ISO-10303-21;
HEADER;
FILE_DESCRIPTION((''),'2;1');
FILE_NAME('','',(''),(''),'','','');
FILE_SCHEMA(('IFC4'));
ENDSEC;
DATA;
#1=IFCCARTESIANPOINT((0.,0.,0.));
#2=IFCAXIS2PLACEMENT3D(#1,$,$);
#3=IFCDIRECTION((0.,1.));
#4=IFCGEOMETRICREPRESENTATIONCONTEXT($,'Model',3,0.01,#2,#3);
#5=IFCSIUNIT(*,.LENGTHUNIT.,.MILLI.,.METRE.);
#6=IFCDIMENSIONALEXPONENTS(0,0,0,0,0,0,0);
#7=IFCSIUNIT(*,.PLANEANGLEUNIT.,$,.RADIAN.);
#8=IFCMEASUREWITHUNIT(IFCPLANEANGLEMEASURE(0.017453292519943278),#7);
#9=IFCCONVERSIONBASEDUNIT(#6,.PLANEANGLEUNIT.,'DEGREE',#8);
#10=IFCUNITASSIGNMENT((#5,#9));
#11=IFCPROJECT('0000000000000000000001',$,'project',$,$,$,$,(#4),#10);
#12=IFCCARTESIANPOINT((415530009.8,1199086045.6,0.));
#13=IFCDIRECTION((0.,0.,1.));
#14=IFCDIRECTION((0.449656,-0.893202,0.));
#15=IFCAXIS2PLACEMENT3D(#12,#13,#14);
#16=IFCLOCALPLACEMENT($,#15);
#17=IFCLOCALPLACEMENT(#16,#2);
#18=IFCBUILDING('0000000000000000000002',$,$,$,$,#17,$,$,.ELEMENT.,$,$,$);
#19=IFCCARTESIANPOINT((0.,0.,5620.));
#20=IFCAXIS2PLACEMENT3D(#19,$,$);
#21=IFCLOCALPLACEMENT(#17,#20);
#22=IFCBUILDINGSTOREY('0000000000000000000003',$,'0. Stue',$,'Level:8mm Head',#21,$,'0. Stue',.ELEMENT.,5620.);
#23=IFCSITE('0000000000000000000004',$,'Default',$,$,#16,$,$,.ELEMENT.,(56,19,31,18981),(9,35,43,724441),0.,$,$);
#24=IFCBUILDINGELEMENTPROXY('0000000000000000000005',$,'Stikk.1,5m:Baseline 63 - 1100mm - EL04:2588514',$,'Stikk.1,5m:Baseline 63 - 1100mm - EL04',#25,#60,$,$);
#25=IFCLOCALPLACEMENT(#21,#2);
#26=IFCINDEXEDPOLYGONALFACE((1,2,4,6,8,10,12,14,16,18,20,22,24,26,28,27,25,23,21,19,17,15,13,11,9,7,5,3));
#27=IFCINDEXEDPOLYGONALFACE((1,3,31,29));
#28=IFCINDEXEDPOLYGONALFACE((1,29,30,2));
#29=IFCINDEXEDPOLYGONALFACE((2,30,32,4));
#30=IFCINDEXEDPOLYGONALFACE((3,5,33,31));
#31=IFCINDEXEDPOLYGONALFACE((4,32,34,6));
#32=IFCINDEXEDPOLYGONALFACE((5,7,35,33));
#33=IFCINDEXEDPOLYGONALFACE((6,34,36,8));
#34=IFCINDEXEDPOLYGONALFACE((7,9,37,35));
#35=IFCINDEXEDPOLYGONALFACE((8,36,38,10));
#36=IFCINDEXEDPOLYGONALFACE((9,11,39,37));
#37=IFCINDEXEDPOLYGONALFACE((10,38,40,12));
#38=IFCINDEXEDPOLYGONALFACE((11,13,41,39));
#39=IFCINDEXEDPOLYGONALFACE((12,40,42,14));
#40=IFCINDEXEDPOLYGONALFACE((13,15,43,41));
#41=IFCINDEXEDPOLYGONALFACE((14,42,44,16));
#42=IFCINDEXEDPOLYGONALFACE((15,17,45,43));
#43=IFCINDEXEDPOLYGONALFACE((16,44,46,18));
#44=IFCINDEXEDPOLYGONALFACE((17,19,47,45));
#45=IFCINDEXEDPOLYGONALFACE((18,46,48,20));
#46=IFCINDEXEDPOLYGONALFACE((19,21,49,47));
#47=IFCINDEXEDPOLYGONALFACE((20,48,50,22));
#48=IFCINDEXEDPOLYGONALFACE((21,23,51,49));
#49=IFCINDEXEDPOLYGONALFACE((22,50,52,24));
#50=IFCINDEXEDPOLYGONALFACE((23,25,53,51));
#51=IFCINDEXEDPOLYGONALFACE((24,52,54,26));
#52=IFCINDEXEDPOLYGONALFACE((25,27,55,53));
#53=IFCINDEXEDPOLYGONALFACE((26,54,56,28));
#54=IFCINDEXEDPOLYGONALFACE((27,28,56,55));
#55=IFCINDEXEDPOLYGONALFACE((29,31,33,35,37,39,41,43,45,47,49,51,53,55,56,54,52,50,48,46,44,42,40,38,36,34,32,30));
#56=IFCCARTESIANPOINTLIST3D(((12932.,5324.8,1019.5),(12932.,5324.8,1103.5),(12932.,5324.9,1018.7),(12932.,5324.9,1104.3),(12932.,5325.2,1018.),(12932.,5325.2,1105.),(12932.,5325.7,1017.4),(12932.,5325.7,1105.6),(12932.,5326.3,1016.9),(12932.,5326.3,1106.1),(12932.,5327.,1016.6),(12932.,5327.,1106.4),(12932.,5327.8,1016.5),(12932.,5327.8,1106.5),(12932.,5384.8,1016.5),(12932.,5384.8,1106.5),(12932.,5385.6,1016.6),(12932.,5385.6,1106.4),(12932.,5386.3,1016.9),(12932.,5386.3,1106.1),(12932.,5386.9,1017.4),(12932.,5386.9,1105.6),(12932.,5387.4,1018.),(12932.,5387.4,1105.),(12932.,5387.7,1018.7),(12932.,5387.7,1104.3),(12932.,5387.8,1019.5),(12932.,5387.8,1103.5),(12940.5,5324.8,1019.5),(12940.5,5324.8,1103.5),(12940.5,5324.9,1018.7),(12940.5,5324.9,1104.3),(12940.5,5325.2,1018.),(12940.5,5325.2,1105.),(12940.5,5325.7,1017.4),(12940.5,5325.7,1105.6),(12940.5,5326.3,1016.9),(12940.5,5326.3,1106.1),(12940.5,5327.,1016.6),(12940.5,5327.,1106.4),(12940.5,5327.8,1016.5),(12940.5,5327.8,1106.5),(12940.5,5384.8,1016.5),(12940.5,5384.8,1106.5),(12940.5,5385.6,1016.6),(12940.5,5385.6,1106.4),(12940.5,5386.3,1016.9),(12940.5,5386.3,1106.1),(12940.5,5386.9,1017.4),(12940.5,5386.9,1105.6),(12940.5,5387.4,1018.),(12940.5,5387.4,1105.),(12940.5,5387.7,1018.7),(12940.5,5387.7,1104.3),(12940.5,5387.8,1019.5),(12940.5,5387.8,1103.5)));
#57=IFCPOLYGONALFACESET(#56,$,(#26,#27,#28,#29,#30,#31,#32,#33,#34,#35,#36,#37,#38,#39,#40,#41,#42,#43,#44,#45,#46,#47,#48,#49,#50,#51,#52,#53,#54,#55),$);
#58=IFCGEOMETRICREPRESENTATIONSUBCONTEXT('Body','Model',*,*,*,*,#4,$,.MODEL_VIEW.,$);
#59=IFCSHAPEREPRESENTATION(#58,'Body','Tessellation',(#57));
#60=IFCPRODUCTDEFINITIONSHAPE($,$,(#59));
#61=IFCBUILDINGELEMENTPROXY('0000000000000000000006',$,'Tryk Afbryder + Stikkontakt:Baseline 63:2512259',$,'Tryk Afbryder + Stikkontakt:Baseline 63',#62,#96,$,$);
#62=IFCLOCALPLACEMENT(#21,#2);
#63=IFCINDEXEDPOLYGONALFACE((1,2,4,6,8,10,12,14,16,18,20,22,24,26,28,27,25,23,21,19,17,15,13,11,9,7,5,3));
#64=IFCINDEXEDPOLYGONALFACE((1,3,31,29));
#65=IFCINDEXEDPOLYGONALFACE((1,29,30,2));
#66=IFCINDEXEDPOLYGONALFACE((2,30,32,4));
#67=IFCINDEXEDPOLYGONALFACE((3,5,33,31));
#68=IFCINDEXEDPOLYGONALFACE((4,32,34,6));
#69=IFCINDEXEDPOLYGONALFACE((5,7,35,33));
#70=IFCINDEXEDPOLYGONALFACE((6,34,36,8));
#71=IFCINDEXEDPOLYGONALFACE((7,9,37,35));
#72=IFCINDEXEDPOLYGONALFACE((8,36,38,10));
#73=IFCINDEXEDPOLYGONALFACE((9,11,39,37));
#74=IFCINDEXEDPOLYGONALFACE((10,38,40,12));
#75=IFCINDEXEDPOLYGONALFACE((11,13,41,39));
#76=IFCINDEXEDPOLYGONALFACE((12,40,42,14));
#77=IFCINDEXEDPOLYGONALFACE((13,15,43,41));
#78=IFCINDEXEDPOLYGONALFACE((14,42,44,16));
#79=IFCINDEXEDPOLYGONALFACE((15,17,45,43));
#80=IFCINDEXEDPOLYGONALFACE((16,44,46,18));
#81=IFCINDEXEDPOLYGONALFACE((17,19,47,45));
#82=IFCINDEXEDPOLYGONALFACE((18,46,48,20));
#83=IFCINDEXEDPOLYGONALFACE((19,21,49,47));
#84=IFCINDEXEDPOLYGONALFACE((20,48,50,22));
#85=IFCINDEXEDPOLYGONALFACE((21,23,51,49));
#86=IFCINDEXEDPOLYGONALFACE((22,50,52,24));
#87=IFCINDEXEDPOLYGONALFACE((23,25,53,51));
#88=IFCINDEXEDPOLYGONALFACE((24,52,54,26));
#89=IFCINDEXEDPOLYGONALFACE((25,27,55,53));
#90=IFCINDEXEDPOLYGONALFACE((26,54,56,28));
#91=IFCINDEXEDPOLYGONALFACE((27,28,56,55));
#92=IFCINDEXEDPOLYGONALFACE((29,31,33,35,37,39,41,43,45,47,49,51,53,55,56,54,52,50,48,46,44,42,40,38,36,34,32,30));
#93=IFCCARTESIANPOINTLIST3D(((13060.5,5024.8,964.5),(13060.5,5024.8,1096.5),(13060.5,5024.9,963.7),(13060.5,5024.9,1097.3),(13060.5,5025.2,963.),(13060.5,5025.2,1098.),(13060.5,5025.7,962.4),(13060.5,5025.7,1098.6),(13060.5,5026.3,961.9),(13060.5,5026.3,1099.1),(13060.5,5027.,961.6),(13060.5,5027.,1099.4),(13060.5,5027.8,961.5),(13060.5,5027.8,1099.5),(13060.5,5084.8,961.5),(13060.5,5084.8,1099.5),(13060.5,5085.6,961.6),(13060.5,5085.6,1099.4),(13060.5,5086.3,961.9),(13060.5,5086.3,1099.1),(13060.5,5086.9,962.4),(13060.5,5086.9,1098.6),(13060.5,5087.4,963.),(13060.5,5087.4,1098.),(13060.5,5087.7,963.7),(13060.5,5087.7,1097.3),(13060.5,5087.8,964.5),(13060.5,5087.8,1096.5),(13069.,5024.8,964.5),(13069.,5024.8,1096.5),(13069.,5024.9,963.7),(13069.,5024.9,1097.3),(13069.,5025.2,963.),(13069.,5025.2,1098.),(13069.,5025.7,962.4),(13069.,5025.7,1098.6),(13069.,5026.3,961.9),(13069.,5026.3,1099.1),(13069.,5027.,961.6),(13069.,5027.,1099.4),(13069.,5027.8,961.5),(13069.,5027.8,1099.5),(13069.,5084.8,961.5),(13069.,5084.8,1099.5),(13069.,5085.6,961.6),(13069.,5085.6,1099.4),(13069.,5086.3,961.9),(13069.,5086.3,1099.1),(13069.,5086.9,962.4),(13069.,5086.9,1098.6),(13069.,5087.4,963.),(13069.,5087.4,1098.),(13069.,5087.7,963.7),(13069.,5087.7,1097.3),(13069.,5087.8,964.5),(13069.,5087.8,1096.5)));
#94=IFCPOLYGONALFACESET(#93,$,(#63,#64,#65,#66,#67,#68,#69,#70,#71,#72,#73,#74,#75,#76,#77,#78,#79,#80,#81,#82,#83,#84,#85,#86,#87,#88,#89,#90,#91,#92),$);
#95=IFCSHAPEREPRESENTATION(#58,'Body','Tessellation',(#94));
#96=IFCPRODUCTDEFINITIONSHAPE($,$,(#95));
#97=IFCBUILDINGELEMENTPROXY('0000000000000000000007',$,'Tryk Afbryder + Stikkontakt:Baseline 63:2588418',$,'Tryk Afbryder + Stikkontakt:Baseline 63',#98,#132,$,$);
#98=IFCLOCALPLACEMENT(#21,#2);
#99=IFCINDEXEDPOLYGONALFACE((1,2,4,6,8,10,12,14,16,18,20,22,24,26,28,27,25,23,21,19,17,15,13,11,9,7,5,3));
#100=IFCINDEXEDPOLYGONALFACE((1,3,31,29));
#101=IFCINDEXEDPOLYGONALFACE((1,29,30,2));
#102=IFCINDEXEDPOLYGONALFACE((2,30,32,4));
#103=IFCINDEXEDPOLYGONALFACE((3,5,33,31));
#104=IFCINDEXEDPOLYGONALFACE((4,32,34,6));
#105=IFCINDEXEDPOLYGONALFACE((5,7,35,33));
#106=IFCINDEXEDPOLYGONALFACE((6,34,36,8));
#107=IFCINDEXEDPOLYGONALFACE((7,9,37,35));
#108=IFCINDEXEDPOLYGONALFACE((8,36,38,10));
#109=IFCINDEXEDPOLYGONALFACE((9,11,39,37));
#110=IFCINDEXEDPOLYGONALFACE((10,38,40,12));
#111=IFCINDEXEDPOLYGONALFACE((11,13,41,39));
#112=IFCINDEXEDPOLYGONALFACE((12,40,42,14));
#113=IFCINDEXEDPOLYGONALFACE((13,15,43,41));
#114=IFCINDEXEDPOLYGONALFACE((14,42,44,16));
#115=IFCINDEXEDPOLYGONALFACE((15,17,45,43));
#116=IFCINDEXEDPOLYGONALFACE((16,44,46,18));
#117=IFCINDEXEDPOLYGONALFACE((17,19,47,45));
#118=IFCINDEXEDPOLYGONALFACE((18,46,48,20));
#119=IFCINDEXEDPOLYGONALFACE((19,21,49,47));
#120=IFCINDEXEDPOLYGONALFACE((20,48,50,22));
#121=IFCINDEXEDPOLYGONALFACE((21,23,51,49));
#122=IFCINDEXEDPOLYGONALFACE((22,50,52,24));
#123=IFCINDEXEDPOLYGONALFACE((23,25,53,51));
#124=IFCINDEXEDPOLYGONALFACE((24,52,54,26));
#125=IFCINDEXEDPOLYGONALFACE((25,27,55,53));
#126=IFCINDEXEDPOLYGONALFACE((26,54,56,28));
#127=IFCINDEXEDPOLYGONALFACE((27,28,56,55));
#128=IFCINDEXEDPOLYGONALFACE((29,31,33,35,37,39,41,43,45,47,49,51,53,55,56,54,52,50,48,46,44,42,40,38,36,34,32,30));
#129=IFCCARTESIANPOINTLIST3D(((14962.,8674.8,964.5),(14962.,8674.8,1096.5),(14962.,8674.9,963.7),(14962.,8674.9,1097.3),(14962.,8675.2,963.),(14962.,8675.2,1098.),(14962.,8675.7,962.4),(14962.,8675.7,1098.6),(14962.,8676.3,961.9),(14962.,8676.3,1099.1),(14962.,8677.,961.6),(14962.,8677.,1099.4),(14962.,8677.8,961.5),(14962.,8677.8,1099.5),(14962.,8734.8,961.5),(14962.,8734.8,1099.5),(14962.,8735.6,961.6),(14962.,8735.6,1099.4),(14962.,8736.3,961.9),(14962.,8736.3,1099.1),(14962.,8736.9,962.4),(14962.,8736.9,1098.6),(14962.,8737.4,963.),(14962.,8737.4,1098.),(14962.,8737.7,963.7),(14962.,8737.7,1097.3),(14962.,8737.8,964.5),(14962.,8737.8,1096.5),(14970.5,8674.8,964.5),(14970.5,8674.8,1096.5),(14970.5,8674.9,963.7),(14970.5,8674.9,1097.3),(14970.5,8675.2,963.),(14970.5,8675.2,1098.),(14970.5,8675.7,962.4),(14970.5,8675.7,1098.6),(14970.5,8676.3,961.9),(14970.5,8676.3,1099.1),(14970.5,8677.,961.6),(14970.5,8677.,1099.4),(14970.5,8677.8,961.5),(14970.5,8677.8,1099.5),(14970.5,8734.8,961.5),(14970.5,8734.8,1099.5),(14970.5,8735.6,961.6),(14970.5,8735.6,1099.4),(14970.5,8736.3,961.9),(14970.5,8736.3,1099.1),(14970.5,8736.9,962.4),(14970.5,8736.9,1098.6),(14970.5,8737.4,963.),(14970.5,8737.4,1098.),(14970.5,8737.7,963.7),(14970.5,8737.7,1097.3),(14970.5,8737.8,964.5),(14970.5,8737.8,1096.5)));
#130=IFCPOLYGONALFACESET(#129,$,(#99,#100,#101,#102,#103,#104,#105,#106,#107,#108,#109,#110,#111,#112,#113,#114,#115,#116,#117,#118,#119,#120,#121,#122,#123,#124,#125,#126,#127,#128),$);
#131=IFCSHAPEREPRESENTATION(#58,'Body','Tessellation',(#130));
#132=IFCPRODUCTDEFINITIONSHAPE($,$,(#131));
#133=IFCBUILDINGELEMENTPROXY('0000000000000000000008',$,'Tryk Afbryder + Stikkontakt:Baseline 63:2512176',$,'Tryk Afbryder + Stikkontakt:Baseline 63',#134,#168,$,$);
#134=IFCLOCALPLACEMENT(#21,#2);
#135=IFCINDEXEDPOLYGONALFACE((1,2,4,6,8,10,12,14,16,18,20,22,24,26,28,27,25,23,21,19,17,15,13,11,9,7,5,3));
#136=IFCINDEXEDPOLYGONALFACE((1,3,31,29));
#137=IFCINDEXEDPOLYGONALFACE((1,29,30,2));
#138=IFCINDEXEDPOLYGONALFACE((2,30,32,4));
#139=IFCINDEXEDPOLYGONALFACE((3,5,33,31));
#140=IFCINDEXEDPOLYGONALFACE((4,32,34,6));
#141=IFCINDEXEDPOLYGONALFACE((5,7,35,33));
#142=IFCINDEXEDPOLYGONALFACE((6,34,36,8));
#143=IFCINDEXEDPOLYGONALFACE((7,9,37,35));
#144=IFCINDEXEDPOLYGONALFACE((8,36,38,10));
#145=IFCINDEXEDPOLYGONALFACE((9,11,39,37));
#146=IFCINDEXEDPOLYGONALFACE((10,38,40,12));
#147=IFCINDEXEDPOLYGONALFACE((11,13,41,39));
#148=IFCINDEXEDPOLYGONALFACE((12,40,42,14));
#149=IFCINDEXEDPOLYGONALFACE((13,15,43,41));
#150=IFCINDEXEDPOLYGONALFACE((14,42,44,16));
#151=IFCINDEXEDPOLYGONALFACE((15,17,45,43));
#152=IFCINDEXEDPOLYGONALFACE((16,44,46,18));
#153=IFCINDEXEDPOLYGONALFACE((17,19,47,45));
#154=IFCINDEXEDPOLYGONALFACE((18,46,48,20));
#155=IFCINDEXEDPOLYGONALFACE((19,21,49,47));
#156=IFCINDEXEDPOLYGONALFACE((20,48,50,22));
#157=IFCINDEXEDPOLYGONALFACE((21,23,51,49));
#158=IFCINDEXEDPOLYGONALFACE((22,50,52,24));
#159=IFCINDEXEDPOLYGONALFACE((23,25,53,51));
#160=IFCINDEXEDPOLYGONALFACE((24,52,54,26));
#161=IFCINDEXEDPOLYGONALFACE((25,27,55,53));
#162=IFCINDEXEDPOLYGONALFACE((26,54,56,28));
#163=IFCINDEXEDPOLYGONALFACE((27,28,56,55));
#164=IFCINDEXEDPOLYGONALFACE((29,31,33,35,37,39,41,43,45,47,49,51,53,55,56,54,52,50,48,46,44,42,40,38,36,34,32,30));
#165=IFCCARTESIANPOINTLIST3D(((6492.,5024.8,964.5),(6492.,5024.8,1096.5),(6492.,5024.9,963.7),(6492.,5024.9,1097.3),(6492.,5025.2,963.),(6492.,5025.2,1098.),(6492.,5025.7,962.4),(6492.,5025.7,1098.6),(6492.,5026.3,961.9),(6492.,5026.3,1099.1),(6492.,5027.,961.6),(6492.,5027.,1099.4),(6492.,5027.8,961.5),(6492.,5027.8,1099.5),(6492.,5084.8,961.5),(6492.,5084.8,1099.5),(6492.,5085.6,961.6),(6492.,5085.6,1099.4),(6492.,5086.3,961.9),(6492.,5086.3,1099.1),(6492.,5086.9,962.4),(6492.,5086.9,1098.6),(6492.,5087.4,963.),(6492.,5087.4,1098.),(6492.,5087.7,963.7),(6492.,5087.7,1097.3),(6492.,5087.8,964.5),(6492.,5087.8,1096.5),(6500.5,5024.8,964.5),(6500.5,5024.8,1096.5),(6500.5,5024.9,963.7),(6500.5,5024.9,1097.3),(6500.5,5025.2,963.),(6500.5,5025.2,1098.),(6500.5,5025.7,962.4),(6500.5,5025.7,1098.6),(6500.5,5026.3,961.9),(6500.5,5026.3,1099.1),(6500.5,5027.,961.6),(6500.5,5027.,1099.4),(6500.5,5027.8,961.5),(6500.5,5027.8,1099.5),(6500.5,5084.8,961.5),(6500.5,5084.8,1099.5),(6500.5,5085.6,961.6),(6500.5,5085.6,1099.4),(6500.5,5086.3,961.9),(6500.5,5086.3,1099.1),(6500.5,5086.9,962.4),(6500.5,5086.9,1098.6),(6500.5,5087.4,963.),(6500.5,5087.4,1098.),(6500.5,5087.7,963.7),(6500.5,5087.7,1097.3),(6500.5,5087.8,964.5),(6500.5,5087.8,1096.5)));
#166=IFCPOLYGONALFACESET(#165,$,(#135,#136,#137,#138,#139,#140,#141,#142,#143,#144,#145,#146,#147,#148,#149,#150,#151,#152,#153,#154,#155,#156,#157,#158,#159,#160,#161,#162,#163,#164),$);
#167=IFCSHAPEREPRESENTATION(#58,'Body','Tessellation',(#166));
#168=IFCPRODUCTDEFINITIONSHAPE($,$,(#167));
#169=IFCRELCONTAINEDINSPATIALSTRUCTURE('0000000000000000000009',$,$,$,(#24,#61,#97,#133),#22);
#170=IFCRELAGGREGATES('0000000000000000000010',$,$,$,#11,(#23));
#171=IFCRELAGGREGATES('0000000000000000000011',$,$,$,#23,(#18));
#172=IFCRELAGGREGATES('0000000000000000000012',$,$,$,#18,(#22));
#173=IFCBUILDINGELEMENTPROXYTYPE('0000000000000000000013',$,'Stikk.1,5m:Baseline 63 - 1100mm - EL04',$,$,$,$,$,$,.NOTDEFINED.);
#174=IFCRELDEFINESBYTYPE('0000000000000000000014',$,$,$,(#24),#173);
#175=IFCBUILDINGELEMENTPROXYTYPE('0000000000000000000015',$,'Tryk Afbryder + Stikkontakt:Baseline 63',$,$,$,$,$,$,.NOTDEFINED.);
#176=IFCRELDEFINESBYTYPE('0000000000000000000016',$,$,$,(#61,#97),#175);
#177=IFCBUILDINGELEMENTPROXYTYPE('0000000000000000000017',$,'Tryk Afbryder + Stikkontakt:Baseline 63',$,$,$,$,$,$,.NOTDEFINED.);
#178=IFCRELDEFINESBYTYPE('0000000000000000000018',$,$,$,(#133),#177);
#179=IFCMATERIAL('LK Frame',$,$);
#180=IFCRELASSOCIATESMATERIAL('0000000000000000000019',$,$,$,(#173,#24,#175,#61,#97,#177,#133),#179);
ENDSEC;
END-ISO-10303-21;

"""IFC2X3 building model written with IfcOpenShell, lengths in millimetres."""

from ifc_helpers import new_model, entity, si_unit, converted_unit, direction, frame, frame_2d, origin, place, context, subcontext, project, spatial, polyline, circle_curve, parameter, trimmed, segment, composite_curve, outline, extrude, source, transform, mapped, material, type_object, type_shapes, element, save


model = new_model("IFC2X3")

# Units and contexts
model_context = context("Model", 3, precision=0.01, world=origin(), true_north=direction((0.0, 1.0)))
body_context = subcontext(model_context, "Body", "Model", "MODEL_VIEW")
ifc_project = project(units=[si_unit("LENGTHUNIT", "METRE", prefix="MILLI"), converted_unit("PLANEANGLEUNIT", "DEGREE", entity("IfcPlaneAngleMeasure", 0.017453292519943278), si_unit("PLANEANGLEUNIT", "RADIAN"), dimensions=[0, 0, 0, 0, 0, 0, 0])], contexts=[model_context])

# Site, building, storey
site_placement = place(None, frame((415530009.8, 1199086045.6, 0.0), z_axis=(0.0, 0.0, 1.0), x_axis=(0.449656, -0.893202, 0.0)))
site = spatial("IfcSite", under=ifc_project, at=site_placement, Name="Default", CompositionType="ELEMENT", RefLatitude=(56, 19, 31, 18981), RefLongitude=(9, 35, 43, 724441), RefElevation=0.0)
building_placement = place(site_placement, origin())
building = spatial("IfcBuilding", under=site, at=building_placement, CompositionType="ELEMENT")
storey_placement = place(building_placement, frame((0.0, 0.0, 5620.0)))
storey = spatial("IfcBuildingStorey", under=building, at=storey_placement, Name="0. Stue", ObjectType="Level:8mm Head", LongName="0. Stue", CompositionType="ELEMENT", Elevation=5620.0)

# Building element proxies
ifc_material_1 = material(Name="LK Frame")
building_element_proxy_type_1 = type_object("IfcBuildingElementProxyType", Name="Stikk.1,5m:Baseline 63 - 1100mm - EL04", PredefinedType="NOTDEFINED", material=ifc_material_1)
shared_shape_1 = source(origin(), body_context, "Body", "SweptSolid", [
    extrude(outline(composite_curve([segment(polyline([(-42.0, -31.5), (42.0, -31.5)]), True, "CONTINUOUS"), segment(trimmed(circle_curve(frame_2d((42.0, -28.5), x_axis=(-1.0, 0.0)), 3.0), [parameter(90.0)], [parameter(180.0)], True, "PARAMETER"), True, "CONTINUOUS"), segment(polyline([(45.0, -28.5), (45.0, 28.5)]), True, "CONTINUOUS"), segment(trimmed(circle_curve(frame_2d((42.0, 28.5), x_axis=(-1.0, 0.0)), 3.0), [parameter(180.0)], [parameter(270.0)], True, "PARAMETER"), True, "CONTINUOUS"), segment(polyline([(42.0, 31.5), (-42.0, 31.5)]), True, "CONTINUOUS"), segment(trimmed(circle_curve(frame_2d((-42.0, 28.5), x_axis=(1.0, 0.0)), 3.0), [parameter(90.0)], [parameter(180.0)], True, "PARAMETER"), True, "CONTINUOUS"), segment(polyline([(-45.0, 28.5), (-45.0, -28.5)]), True, "CONTINUOUS"), segment(trimmed(circle_curve(frame_2d((-42.0, -28.5), x_axis=(1.0, 0.0)), 3.0), [parameter(180.0)], [parameter(270.0)], True, "PARAMETER"), True, "CONTINUOUS")], self_intersect=False)), frame((0.0, -38.5, 0.0), z_axis=(0.0, 0.0, 1.0), x_axis=(0.0, 1.0, 0.0)), (0.0, 0.0, 1.0), 8.5),
])
type_shapes(building_element_proxy_type_1, [shared_shape_1])
for number, where, z_axis, x_axis, name in (
    (1, (12940.5, 5356.3, 1100.0), (-1.0, 0.0, 0.0), (0.0, -1.0, 0.0), "Stikk.1,5m:Baseline 63 - 1100mm - EL04:2588514"),
):
    element("IfcBuildingElementProxy", number, at=place(storey_placement, frame(where, z_axis=z_axis, x_axis=x_axis)), inside=storey, type_object=building_element_proxy_type_1, material=ifc_material_1, Name=name, ObjectType="Stikk.1,5m:Baseline 63 - 1100mm - EL04", context=body_context, shape_type="MappedRepresentation", body=[
        mapped(shared_shape_1, transform((0.0, 0.0, 0.0), scale=1.0)),
    ])
building_element_proxy_type_2 = type_object("IfcBuildingElementProxyType", Name="Tryk Afbryder + Stikkontakt:Baseline 63", PredefinedType="NOTDEFINED", material=ifc_material_1)
shared_shape_2 = source(origin(), body_context, "Body", "SweptSolid", [
    extrude(outline(composite_curve([segment(polyline([(-66.0, -31.5), (66.0, -31.5)]), True, "CONTINUOUS"), segment(trimmed(circle_curve(frame_2d((66.0, -28.5), x_axis=(-1.0, 0.0)), 3.0), [parameter(90.0)], [parameter(180.0)], True, "PARAMETER"), True, "CONTINUOUS"), segment(polyline([(69.0, -28.5), (69.0, 28.5)]), True, "CONTINUOUS"), segment(trimmed(circle_curve(frame_2d((66.0, 28.5), x_axis=(-1.0, 0.0)), 3.0), [parameter(180.0)], [parameter(270.0)], True, "PARAMETER"), True, "CONTINUOUS"), segment(polyline([(66.0, 31.5), (-66.0, 31.5)]), True, "CONTINUOUS"), segment(trimmed(circle_curve(frame_2d((-66.0, 28.5), x_axis=(1.0, 0.0)), 3.0), [parameter(90.0)], [parameter(180.0)], True, "PARAMETER"), True, "CONTINUOUS"), segment(polyline([(-69.0, 28.5), (-69.0, -28.5)]), True, "CONTINUOUS"), segment(trimmed(circle_curve(frame_2d((-66.0, -28.5), x_axis=(1.0, 0.0)), 3.0), [parameter(180.0)], [parameter(270.0)], True, "PARAMETER"), True, "CONTINUOUS")], self_intersect=False)), frame((0.0, -69.5, 0.0), z_axis=(0.0, 0.0, 1.0), x_axis=(0.0, 1.0, 0.0)), (0.0, 0.0, 1.0), 8.5),
])
type_shapes(building_element_proxy_type_2, [shared_shape_2])
for number, where, z_axis, x_axis, name in (
    (2, (13060.5, 5056.3, 1100.0), (1.0, 0.0, 0.0), (0.0, 1.0, 0.0), "Tryk Afbryder + Stikkontakt:Baseline 63:2512259"),
    (3, (14970.5, 8706.3, 1100.0), (-1.0, 0.0, 0.0), (0.0, -1.0, 0.0), "Tryk Afbryder + Stikkontakt:Baseline 63:2588418"),
):
    element("IfcBuildingElementProxy", number, at=place(storey_placement, frame(where, z_axis=z_axis, x_axis=x_axis)), inside=storey, type_object=building_element_proxy_type_2, material=ifc_material_1, Name=name, ObjectType="Tryk Afbryder + Stikkontakt:Baseline 63", context=body_context, shape_type="MappedRepresentation", body=[
        mapped(shared_shape_2, transform((0.0, 0.0, 0.0), scale=1.0)),
    ])
building_element_proxy_type_3 = type_object("IfcBuildingElementProxyType", Name="Tryk Afbryder + Stikkontakt:Baseline 63", PredefinedType="NOTDEFINED", material=ifc_material_1)
shared_shape_3 = source(origin(), body_context, "Body", "SweptSolid", [
    extrude(outline(composite_curve([segment(trimmed(circle_curve(frame_2d((-66.0, 28.5), x_axis=(1.0, 0.0)), 3.0), [parameter(90.0)], [parameter(180.0)], True, "PARAMETER"), True, "CONTINUOUS"), segment(polyline([(-69.0, 28.5), (-69.0, -28.5)]), True, "CONTINUOUS"), segment(trimmed(circle_curve(frame_2d((-66.0, -28.5), x_axis=(1.0, 0.0)), 3.0), [parameter(180.0)], [parameter(270.0)], True, "PARAMETER"), True, "CONTINUOUS"), segment(polyline([(-66.0, -31.5), (66.0, -31.5)]), True, "CONTINUOUS"), segment(trimmed(circle_curve(frame_2d((66.0, -28.5), x_axis=(-1.0, 0.0)), 3.0), [parameter(90.0)], [parameter(180.0)], True, "PARAMETER"), True, "CONTINUOUS"), segment(polyline([(69.0, -28.5), (69.0, 28.5)]), True, "CONTINUOUS"), segment(trimmed(circle_curve(frame_2d((66.0, 28.5), x_axis=(-1.0, 0.0)), 3.0), [parameter(180.0)], [parameter(270.0)], True, "PARAMETER"), True, "CONTINUOUS"), segment(polyline([(66.0, 31.5), (-66.0, 31.5)]), True, "CONTINUOUS")], self_intersect=False)), frame((0.0, 69.5, 0.0), z_axis=(0.0, 0.0, 1.0), x_axis=(0.0, -1.0, 0.0)), (0.0, 0.0, 1.0), 8.5),
])
type_shapes(building_element_proxy_type_3, [shared_shape_3])
proxy_1_placement = place(storey_placement, frame((6500.5, 5056.3, 1100.0), z_axis=(-1.0, 0.0, 0.0), x_axis=(0.0, 1.0, 0.0)))
element("IfcBuildingElementProxy", 4, at=proxy_1_placement, inside=storey, type_object=building_element_proxy_type_3, material=ifc_material_1, Name="Tryk Afbryder + Stikkontakt:Baseline 63:2512176", ObjectType="Tryk Afbryder + Stikkontakt:Baseline 63", context=body_context, shape_type="MappedRepresentation", body=[
    mapped(shared_shape_3, transform((0.0, 0.0, 0.0), scale=1.0)),
])

save(model, "model.ifc")
